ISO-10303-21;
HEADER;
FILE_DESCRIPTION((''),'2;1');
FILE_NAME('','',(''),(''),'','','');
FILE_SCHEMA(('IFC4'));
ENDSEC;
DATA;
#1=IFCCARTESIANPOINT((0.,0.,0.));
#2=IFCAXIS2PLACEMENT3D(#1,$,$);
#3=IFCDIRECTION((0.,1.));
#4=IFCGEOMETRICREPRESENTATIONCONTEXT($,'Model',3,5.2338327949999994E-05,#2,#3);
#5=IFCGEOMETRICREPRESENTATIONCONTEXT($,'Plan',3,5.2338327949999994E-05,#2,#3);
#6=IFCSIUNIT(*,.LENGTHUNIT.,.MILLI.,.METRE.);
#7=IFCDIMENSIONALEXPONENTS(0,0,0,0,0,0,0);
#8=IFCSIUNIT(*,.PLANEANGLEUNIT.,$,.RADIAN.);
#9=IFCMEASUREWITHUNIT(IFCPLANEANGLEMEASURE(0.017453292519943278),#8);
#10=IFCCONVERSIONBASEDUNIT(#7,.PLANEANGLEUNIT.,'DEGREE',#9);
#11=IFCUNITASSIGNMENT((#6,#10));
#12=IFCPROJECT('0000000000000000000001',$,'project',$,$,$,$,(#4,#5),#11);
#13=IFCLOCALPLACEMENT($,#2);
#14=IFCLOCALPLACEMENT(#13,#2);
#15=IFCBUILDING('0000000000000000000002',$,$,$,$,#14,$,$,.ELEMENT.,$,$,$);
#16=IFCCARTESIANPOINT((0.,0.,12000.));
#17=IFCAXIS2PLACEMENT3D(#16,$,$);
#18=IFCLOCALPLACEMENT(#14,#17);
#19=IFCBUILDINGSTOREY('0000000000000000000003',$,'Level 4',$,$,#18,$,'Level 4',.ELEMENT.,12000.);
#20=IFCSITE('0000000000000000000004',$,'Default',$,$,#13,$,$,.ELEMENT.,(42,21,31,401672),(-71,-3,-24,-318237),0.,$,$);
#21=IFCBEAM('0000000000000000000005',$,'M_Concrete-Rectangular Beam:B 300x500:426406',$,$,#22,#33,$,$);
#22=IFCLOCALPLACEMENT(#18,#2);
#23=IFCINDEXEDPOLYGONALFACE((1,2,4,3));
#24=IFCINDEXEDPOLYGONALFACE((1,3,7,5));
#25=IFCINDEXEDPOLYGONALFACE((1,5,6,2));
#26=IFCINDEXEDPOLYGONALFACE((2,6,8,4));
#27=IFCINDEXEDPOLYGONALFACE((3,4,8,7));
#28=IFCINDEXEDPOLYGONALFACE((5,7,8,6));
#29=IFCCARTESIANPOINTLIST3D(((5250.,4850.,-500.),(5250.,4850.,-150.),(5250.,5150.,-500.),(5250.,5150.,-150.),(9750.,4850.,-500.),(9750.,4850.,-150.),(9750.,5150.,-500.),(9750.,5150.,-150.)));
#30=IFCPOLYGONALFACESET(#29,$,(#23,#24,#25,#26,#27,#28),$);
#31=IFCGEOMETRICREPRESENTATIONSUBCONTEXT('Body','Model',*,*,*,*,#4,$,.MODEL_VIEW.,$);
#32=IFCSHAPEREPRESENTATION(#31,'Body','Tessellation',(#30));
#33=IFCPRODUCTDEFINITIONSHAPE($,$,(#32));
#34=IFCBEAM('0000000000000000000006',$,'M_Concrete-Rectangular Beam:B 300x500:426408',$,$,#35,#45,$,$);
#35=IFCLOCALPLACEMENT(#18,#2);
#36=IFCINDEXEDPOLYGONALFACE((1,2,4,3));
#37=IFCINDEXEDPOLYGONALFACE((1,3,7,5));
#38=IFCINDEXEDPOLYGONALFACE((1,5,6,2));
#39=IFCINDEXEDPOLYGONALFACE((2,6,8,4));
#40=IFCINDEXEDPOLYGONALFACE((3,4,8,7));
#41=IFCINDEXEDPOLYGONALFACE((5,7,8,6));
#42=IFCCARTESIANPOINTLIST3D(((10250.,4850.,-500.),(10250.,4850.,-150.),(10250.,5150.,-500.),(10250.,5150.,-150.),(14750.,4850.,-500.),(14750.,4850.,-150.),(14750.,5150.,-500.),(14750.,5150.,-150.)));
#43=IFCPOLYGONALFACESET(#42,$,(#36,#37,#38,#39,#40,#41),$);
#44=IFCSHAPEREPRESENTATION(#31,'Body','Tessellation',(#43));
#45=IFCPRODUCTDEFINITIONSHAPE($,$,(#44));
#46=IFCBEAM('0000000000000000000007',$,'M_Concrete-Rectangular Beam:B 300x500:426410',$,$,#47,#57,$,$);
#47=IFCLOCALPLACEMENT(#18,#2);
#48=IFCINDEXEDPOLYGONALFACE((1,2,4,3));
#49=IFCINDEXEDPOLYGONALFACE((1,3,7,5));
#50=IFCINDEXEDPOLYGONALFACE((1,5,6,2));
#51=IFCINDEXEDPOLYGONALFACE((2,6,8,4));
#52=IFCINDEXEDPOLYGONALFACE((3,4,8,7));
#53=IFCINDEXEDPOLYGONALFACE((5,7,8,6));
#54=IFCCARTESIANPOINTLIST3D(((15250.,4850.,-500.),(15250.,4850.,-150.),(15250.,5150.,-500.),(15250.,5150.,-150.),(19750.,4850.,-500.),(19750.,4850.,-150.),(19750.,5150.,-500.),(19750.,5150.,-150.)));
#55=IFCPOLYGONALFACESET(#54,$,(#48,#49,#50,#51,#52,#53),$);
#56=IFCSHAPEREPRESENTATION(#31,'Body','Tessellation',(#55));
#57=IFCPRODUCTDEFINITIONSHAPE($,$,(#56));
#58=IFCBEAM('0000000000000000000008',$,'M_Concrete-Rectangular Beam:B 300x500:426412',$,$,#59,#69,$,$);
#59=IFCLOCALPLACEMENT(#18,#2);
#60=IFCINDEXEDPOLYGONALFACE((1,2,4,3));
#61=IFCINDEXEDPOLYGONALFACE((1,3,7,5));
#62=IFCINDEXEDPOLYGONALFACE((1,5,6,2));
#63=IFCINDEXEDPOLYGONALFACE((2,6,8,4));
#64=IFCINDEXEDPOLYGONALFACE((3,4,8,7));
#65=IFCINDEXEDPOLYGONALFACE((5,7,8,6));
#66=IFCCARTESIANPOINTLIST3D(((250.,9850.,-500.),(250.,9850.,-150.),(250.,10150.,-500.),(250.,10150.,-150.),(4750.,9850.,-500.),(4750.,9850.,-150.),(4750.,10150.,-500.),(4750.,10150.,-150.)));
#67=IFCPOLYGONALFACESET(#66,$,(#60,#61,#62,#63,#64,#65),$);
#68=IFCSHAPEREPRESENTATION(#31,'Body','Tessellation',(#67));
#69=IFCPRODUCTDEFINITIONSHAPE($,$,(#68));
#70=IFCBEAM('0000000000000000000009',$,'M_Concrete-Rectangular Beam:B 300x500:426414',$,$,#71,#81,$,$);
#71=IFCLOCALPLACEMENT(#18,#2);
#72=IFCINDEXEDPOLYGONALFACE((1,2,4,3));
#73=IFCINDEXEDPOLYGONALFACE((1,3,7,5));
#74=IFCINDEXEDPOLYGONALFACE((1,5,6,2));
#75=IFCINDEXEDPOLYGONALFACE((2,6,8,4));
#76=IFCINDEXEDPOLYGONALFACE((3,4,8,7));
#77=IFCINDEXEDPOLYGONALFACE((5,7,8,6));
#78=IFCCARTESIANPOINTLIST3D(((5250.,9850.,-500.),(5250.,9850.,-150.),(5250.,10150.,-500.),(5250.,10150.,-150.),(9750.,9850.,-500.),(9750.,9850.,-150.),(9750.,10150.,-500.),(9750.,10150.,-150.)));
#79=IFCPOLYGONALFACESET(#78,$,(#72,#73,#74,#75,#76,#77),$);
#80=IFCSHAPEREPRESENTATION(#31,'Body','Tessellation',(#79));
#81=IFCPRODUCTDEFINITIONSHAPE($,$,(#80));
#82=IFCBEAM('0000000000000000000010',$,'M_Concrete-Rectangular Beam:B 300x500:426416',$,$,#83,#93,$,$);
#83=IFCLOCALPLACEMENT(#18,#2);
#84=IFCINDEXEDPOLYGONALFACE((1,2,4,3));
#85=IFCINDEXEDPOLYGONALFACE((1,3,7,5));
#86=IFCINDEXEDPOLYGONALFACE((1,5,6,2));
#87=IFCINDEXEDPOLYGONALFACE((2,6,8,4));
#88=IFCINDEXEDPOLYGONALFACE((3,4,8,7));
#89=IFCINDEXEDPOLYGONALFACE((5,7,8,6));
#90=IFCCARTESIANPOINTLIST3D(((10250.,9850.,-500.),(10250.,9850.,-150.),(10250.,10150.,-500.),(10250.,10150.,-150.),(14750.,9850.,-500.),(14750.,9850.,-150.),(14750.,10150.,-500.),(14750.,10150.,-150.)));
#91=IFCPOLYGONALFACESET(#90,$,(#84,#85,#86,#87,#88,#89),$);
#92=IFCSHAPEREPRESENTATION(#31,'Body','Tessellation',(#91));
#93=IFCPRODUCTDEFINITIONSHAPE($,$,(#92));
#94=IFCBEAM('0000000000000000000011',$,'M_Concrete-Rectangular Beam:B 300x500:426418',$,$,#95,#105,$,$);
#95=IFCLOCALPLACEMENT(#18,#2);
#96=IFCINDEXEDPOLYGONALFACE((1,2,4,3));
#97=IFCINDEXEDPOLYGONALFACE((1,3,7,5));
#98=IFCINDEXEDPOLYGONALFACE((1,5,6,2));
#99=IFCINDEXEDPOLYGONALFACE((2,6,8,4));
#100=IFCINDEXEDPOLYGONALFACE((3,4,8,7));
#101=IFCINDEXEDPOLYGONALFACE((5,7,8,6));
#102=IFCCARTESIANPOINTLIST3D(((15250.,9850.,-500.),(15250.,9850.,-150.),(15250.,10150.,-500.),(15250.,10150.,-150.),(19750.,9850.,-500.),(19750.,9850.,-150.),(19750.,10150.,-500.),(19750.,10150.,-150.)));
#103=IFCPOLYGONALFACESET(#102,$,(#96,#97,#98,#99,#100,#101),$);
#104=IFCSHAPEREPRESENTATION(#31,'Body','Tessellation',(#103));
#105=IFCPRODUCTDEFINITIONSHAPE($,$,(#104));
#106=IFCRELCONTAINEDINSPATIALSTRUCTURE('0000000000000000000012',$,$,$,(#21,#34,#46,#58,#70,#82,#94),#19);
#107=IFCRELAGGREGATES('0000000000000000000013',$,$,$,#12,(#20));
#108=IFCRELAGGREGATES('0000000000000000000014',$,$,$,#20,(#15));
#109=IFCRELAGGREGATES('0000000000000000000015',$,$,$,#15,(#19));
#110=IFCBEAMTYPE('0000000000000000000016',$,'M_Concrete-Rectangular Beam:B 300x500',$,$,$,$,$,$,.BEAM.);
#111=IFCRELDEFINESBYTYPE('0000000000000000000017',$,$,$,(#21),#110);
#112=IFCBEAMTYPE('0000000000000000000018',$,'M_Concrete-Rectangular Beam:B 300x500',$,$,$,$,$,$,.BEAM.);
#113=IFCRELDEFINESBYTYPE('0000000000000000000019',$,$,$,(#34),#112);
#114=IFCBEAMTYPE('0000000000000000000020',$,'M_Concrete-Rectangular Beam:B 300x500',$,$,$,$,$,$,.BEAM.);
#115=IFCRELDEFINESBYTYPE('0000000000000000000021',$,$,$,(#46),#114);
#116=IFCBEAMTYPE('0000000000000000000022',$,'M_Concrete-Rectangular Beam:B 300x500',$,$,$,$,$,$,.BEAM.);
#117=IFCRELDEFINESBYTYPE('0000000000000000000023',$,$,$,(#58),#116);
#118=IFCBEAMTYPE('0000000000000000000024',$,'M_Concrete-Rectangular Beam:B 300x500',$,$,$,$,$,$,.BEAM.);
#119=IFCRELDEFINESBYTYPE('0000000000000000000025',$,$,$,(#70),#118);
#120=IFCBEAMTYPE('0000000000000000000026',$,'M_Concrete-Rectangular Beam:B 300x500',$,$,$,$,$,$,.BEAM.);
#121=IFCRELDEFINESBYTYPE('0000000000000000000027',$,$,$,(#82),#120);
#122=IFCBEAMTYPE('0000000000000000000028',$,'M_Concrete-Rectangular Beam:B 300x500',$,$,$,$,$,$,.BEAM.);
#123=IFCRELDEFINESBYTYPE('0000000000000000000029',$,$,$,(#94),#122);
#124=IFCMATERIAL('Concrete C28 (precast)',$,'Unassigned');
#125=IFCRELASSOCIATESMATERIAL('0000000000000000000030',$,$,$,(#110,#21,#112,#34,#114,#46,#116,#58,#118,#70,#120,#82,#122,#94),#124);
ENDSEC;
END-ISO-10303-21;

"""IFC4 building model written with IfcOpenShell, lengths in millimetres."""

from ifc_helpers import new_model, entity, si_unit, converted_unit, direction, frame, origin, place, context, subcontext, project, spatial, indexed_curve, outline, extrude, source, transform, mapped, material, type_object, type_shapes, element, save


model = new_model("IFC4")

# Units and contexts
model_context = context("Model", 3, precision=5.2338327949999994e-05, world=origin(), true_north=direction((0.0, 1.0)))
plan_context = context("Plan", 3, precision=5.2338327949999994e-05, world=origin(), true_north=direction((0.0, 1.0)))
body_context = subcontext(model_context, "Body", "Model", "MODEL_VIEW")
ifc_project = project(units=[si_unit("LENGTHUNIT", "METRE", prefix="MILLI"), converted_unit("PLANEANGLEUNIT", "DEGREE", entity("IfcPlaneAngleMeasure", 0.017453292519943278), si_unit("PLANEANGLEUNIT", "RADIAN"), dimensions=[0, 0, 0, 0, 0, 0, 0])], contexts=[model_context, plan_context])

# Site, building, storey
site_placement = place(None, origin())
site = spatial("IfcSite", under=ifc_project, at=site_placement, Name="Default", CompositionType="ELEMENT", RefLatitude=(42, 21, 31, 401672), RefLongitude=(-71, -3, -24, -318237), RefElevation=0.0)
building_placement = place(site_placement, origin())
building = spatial("IfcBuilding", under=site, at=building_placement, CompositionType="ELEMENT")
storey_placement = place(building_placement, frame((0.0, 0.0, 12000.0)))
storey = spatial("IfcBuildingStorey", under=building, at=storey_placement, Name="Level 4", LongName="Level 4", CompositionType="ELEMENT", Elevation=12000.0)

# Shared definitions
ifc_material = material(Name="Concrete C28 (precast)", Category="Unassigned")

# Beams
beam_type_1 = type_object("IfcBeamType", Name="M_Concrete-Rectangular Beam:B 300x500", PredefinedType="BEAM", material=ifc_material)
shared_shape_1 = source(origin(), body_context, "Body", "SweptSolid", [
    extrude(outline(indexed_curve([(-175.0, -150.0), (175.0, -150.0), (175.0, 150.0), (-175.0, 150.0), (-175.0, -150.0)], self_intersect=False)), frame((5250.0, 5000.0, 11675.0), z_axis=(1.0, 0.0, 0.0), x_axis=(0.0, 0.0, -1.0)), (0.0, 0.0, 1.0), 4500.0),
])
type_shapes(beam_type_1, [shared_shape_1])
beam_1_placement = place(storey_placement, frame((0.0, 0.0, -12000.0)))
element("IfcBeam", 1, at=beam_1_placement, inside=storey, type_object=beam_type_1, material=ifc_material, Name="M_Concrete-Rectangular Beam:B 300x500:426406", context=body_context, shape_type="MappedRepresentation", body=[
    mapped(shared_shape_1, transform((0.0, 0.0, 0.0), scale=1.0)),
])
beam_type_2 = type_object("IfcBeamType", Name="M_Concrete-Rectangular Beam:B 300x500", PredefinedType="BEAM", material=ifc_material)
shared_shape_2 = source(origin(), body_context, "Body", "SweptSolid", [
    extrude(outline(indexed_curve([(-175.0, -150.0), (175.0, -150.0), (175.0, 150.0), (-175.0, 150.0), (-175.0, -150.0)], self_intersect=False)), frame((10250.0, 5000.0, 11675.0), z_axis=(1.0, 0.0, 0.0), x_axis=(0.0, 0.0, -1.0)), (0.0, 0.0, 1.0), 4500.0),
])
type_shapes(beam_type_2, [shared_shape_2])
beam_2_placement = place(storey_placement, frame((0.0, 0.0, -12000.0)))
element("IfcBeam", 2, at=beam_2_placement, inside=storey, type_object=beam_type_2, material=ifc_material, Name="M_Concrete-Rectangular Beam:B 300x500:426408", context=body_context, shape_type="MappedRepresentation", body=[
    mapped(shared_shape_2, transform((0.0, 0.0, 0.0), scale=1.0)),
])
beam_type_3 = type_object("IfcBeamType", Name="M_Concrete-Rectangular Beam:B 300x500", PredefinedType="BEAM", material=ifc_material)
shared_shape_3 = source(origin(), body_context, "Body", "SweptSolid", [
    extrude(outline(indexed_curve([(-175.0, -150.0), (175.0, -150.0), (175.0, 150.0), (-175.0, 150.0), (-175.0, -150.0)], self_intersect=False)), frame((15250.0, 5000.0, 11675.0), z_axis=(1.0, 0.0, 0.0), x_axis=(0.0, 0.0, -1.0)), (0.0, 0.0, 1.0), 4500.0),
])
type_shapes(beam_type_3, [shared_shape_3])
beam_3_placement = place(storey_placement, frame((0.0, 0.0, -12000.0)))
element("IfcBeam", 3, at=beam_3_placement, inside=storey, type_object=beam_type_3, material=ifc_material, Name="M_Concrete-Rectangular Beam:B 300x500:426410", context=body_context, shape_type="MappedRepresentation", body=[
    mapped(shared_shape_3, transform((0.0, 0.0, 0.0), scale=1.0)),
])
beam_type_4 = type_object("IfcBeamType", Name="M_Concrete-Rectangular Beam:B 300x500", PredefinedType="BEAM", material=ifc_material)
shared_shape_4 = source(origin(), body_context, "Body", "SweptSolid", [
    extrude(outline(indexed_curve([(-175.0, -150.0), (175.0, -150.0), (175.0, 150.0), (-175.0, 150.0), (-175.0, -150.0)], self_intersect=False)), frame((250.0, 10000.0, 11675.0), z_axis=(1.0, 0.0, 0.0), x_axis=(0.0, 0.0, -1.0)), (0.0, 0.0, 1.0), 4500.0),
])
type_shapes(beam_type_4, [shared_shape_4])
beam_4_placement = place(storey_placement, frame((0.0, 0.0, -12000.0)))
element("IfcBeam", 4, at=beam_4_placement, inside=storey, type_object=beam_type_4, material=ifc_material, Name="M_Concrete-Rectangular Beam:B 300x500:426412", context=body_context, shape_type="MappedRepresentation", body=[
    mapped(shared_shape_4, transform((0.0, 0.0, 0.0), scale=1.0)),
])
beam_type_5 = type_object("IfcBeamType", Name="M_Concrete-Rectangular Beam:B 300x500", PredefinedType="BEAM", material=ifc_material)
shared_shape_5 = source(origin(), body_context, "Body", "SweptSolid", [
    extrude(outline(indexed_curve([(-175.0, -150.0), (175.0, -150.0), (175.0, 150.0), (-175.0, 150.0), (-175.0, -150.0)], self_intersect=False)), frame((5250.0, 10000.0, 11675.0), z_axis=(1.0, 0.0, 0.0), x_axis=(0.0, 0.0, -1.0)), (0.0, 0.0, 1.0), 4500.0),
])
type_shapes(beam_type_5, [shared_shape_5])
beam_5_placement = place(storey_placement, frame((0.0, 0.0, -12000.0)))
element("IfcBeam", 5, at=beam_5_placement, inside=storey, type_object=beam_type_5, material=ifc_material, Name="M_Concrete-Rectangular Beam:B 300x500:426414", context=body_context, shape_type="MappedRepresentation", body=[
    mapped(shared_shape_5, transform((0.0, 0.0, 0.0), scale=1.0)),
])
beam_type_6 = type_object("IfcBeamType", Name="M_Concrete-Rectangular Beam:B 300x500", PredefinedType="BEAM", material=ifc_material)
shared_shape_6 = source(origin(), body_context, "Body", "SweptSolid", [
    extrude(outline(indexed_curve([(-175.0, -150.0), (175.0, -150.0), (175.0, 150.0), (-175.0, 150.0), (-175.0, -150.0)], self_intersect=False)), frame((10250.0, 10000.0, 11675.0), z_axis=(1.0, 0.0, 0.0), x_axis=(0.0, 0.0, -1.0)), (0.0, 0.0, 1.0), 4500.0),
])
type_shapes(beam_type_6, [shared_shape_6])
beam_6_placement = place(storey_placement, frame((0.0, 0.0, -12000.0)))
element("IfcBeam", 6, at=beam_6_placement, inside=storey, type_object=beam_type_6, material=ifc_material, Name="M_Concrete-Rectangular Beam:B 300x500:426416", context=body_context, shape_type="MappedRepresentation", body=[
    mapped(shared_shape_6, transform((0.0, 0.0, 0.0), scale=1.0)),
])
beam_type_7 = type_object("IfcBeamType", Name="M_Concrete-Rectangular Beam:B 300x500", PredefinedType="BEAM", material=ifc_material)
shared_shape_7 = source(origin(), body_context, "Body", "SweptSolid", [
    extrude(outline(indexed_curve([(-175.0, -150.0), (175.0, -150.0), (175.0, 150.0), (-175.0, 150.0), (-175.0, -150.0)], self_intersect=False)), frame((15250.0, 10000.0, 11675.0), z_axis=(1.0, 0.0, 0.0), x_axis=(0.0, 0.0, -1.0)), (0.0, 0.0, 1.0), 4500.0),
])
type_shapes(beam_type_7, [shared_shape_7])
beam_7_placement = place(storey_placement, frame((0.0, 0.0, -12000.0)))
element("IfcBeam", 7, at=beam_7_placement, inside=storey, type_object=beam_type_7, material=ifc_material, Name="M_Concrete-Rectangular Beam:B 300x500:426418", context=body_context, shape_type="MappedRepresentation", body=[
    mapped(shared_shape_7, transform((0.0, 0.0, 0.0), scale=1.0)),
])

save(model, "model.ifc")
